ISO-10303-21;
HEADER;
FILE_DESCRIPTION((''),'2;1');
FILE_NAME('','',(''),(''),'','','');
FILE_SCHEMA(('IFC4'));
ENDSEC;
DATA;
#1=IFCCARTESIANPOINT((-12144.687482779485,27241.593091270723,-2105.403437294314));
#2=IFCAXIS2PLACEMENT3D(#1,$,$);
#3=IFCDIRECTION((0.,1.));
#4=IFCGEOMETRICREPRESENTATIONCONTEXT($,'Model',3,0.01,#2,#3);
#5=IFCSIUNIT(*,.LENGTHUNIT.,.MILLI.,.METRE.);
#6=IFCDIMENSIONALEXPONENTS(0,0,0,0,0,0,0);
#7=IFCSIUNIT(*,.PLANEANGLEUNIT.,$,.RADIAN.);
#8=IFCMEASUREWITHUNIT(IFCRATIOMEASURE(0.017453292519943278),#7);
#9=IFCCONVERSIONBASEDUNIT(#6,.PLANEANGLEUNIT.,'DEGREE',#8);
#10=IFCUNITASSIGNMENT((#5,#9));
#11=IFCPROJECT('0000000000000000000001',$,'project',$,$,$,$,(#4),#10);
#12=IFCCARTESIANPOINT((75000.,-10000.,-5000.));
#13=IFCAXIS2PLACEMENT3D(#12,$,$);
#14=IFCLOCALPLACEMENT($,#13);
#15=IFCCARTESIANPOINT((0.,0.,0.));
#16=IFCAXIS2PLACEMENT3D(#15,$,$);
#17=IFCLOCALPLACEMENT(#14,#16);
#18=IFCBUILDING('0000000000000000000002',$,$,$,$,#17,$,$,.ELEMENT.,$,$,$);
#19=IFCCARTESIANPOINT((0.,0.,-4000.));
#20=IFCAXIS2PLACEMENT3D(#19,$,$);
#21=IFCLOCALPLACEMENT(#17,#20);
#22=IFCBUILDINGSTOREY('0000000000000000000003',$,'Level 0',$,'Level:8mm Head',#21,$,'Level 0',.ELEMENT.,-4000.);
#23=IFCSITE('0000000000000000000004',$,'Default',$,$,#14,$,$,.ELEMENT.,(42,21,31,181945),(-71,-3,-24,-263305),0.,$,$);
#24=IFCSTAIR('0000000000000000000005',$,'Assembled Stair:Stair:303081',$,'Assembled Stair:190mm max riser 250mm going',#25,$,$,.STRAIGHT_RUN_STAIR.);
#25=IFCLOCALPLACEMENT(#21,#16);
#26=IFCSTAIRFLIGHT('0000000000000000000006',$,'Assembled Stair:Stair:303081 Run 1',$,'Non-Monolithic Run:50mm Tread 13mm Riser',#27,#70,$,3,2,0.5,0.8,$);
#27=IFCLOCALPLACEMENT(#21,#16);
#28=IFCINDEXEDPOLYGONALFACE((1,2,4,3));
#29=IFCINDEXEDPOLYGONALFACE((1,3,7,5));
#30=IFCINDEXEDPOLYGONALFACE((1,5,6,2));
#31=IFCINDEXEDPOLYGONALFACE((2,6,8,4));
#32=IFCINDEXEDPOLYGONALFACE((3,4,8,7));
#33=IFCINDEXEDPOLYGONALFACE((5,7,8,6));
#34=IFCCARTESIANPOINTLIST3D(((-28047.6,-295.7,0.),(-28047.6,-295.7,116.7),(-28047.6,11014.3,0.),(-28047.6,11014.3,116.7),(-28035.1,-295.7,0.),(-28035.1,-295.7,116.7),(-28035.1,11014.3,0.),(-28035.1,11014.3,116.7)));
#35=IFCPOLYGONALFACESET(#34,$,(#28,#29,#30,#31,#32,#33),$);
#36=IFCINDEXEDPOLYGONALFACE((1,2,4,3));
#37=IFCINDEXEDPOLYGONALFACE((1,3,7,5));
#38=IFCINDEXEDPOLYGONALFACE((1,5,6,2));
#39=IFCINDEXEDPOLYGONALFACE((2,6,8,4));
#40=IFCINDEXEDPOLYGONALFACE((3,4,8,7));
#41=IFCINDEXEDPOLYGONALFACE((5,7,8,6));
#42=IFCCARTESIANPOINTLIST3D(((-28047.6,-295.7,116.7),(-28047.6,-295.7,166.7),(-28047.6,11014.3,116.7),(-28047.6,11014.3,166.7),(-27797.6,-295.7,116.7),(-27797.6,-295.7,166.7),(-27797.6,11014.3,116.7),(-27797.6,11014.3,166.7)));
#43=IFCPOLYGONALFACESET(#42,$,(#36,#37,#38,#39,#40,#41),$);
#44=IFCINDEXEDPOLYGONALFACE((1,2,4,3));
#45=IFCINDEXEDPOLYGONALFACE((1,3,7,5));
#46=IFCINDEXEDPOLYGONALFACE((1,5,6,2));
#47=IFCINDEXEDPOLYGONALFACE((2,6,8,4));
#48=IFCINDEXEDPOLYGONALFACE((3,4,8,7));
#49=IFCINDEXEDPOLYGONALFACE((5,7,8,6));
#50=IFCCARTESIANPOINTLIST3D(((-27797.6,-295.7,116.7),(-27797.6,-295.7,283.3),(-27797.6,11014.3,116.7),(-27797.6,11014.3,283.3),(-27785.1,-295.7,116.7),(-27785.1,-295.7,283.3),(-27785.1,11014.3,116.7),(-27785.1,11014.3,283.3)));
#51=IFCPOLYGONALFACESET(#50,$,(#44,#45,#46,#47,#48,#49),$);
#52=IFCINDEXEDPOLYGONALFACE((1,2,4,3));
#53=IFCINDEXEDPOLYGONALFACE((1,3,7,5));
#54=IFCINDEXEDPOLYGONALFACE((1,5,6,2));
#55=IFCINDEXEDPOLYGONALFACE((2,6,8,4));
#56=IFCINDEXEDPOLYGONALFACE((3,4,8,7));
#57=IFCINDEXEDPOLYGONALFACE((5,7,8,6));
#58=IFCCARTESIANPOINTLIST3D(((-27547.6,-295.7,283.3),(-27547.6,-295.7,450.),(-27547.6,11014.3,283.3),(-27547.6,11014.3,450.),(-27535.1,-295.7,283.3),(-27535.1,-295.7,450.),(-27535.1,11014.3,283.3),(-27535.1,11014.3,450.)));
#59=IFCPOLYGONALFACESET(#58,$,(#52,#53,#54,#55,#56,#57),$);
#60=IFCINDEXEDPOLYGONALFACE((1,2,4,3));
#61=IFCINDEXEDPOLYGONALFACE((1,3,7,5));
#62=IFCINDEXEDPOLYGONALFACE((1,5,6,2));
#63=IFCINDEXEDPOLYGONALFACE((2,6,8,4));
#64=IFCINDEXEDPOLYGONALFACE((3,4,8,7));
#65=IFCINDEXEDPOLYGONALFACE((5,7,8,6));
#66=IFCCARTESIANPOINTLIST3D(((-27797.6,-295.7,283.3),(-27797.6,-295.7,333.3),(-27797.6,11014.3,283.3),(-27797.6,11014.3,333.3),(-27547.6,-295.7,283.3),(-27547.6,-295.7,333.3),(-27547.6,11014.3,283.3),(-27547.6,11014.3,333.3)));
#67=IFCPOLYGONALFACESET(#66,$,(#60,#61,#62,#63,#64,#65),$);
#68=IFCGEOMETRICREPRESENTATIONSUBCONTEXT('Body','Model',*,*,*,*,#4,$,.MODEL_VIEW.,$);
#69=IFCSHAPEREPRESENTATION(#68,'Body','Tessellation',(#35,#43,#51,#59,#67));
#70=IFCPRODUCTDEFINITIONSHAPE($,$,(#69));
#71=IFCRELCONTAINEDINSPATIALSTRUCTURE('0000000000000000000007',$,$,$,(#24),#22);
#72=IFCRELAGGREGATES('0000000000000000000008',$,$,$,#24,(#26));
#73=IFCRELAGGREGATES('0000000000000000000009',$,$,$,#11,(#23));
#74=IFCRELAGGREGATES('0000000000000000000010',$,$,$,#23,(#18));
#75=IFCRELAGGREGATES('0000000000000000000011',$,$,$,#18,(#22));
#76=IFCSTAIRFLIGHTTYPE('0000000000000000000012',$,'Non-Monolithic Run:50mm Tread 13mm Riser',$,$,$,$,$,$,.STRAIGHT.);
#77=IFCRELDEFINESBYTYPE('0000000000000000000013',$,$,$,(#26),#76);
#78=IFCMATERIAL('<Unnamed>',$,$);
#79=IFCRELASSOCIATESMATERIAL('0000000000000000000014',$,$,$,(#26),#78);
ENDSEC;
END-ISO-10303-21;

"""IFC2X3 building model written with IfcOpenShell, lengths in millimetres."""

from ifc_helpers import new_model, entity, si_unit, converted_unit, direction, frame, frame_2d, origin, place, context, subcontext, project, spatial, rectangle, extrude, material, type_object, element, aggregate, save


model = new_model("IFC2X3")

# Units and contexts
model_context = context("Model", 3, precision=0.01, world=frame((-12144.687482779485, 27241.593091270723, -2105.403437294314)), true_north=direction((0.0, 1.0)))
body_context = subcontext(model_context, "Body", "Model", "MODEL_VIEW")
ifc_project = project(units=[si_unit("LENGTHUNIT", "METRE", prefix="MILLI"), converted_unit("PLANEANGLEUNIT", "DEGREE", entity("IfcRatioMeasure", 0.017453292519943278), si_unit("PLANEANGLEUNIT", "RADIAN"), dimensions=[0, 0, 0, 0, 0, 0, 0])], contexts=[model_context])

# Site, building, storey
site_placement = place(None, frame((75000.0, -10000.0, -5000.0)))
site = spatial("IfcSite", under=ifc_project, at=site_placement, Name="Default", CompositionType="ELEMENT", RefLatitude=(42, 21, 31, 181945), RefLongitude=(-71, -3, -24, -263305), RefElevation=0.0)
building_placement = place(site_placement, origin())
building = spatial("IfcBuilding", under=site, at=building_placement, CompositionType="ELEMENT")
storey_placement = place(building_placement, frame((0.0, 0.0, -4000.0)))
storey = spatial("IfcBuildingStorey", under=building, at=storey_placement, Name="Level 0", ObjectType="Level:8mm Head", LongName="Level 0", CompositionType="ELEMENT", Elevation=-4000.0)

# Stair
stair_placement = place(storey_placement, origin())
stair = element("IfcStair", 1, at=stair_placement, inside=storey, Name="Assembled Stair:Stair:303081", ObjectType="Assembled Stair:190mm max riser 250mm going", ShapeType="STRAIGHT_RUN_STAIR")
ifc_material_1 = material(Name="<Unnamed>")

# Stair flight
stair_flight_type = type_object("IfcStairFlightType", Name="Non-Monolithic Run:50mm Tread 13mm Riser", PredefinedType="STRAIGHT")
stair_flight_placement = place(stair_placement, origin())
stair_flight = element("IfcStairFlight", 2, at=stair_flight_placement, type_object=stair_flight_type, material=ifc_material_1, Name="Assembled Stair:Stair:303081 Run 1", ObjectType="Non-Monolithic Run:50mm Tread 13mm Riser", NumberOfRiser=3, NumberOfTreads=2, RiserHeight=0.5, TreadLength=0.8, context=body_context, shape_type="SweptSolid", body=[
    extrude(rectangle(XDim=11310.0, YDim=12.5, at=frame_2d((0.0, 0.0), x_axis=(1.0, 0.0))), frame((-28041.4, 5359.3, 0.0), z_axis=(0.0, 0.0, 1.0), x_axis=(0.0, 1.0, 0.0)), (0.0, 0.0, 1.0), 116.7),
    extrude(rectangle(XDim=250.0, YDim=11310.0, at=frame_2d((0.0, 0.0), x_axis=(1.0, 0.0))), frame((-27922.6, 5359.3, 116.7), z_axis=(0.0, 0.0, 1.0), x_axis=(-1.0, 0.0, 0.0)), (0.0, 0.0, 1.0), 50.0),
    extrude(rectangle(XDim=11310.0, YDim=12.5, at=frame_2d((0.0, 0.0), x_axis=(1.0, 0.0))), frame((-27791.4, 5359.3, 116.7), z_axis=(0.0, 0.0, 1.0), x_axis=(0.0, 1.0, 0.0)), (0.0, 0.0, 1.0), 166.7),
    extrude(rectangle(XDim=11310.0, YDim=12.5, at=frame_2d((0.0, 0.0), x_axis=(1.0, 0.0))), frame((-27541.4, 5359.3, 283.3), z_axis=(0.0, 0.0, 1.0), x_axis=(0.0, 1.0, 0.0)), (0.0, 0.0, 1.0), 166.7),
    extrude(rectangle(XDim=250.0, YDim=11310.0, at=frame_2d((0.0, 0.0), x_axis=(1.0, 0.0))), frame((-27672.6, 5359.3, 283.3), z_axis=(0.0, 0.0, 1.0), x_axis=(-1.0, 0.0, 0.0)), (0.0, 0.0, 1.0), 50.0),
])
aggregate(stair, [stair_flight])

save(model, "model.ifc")
